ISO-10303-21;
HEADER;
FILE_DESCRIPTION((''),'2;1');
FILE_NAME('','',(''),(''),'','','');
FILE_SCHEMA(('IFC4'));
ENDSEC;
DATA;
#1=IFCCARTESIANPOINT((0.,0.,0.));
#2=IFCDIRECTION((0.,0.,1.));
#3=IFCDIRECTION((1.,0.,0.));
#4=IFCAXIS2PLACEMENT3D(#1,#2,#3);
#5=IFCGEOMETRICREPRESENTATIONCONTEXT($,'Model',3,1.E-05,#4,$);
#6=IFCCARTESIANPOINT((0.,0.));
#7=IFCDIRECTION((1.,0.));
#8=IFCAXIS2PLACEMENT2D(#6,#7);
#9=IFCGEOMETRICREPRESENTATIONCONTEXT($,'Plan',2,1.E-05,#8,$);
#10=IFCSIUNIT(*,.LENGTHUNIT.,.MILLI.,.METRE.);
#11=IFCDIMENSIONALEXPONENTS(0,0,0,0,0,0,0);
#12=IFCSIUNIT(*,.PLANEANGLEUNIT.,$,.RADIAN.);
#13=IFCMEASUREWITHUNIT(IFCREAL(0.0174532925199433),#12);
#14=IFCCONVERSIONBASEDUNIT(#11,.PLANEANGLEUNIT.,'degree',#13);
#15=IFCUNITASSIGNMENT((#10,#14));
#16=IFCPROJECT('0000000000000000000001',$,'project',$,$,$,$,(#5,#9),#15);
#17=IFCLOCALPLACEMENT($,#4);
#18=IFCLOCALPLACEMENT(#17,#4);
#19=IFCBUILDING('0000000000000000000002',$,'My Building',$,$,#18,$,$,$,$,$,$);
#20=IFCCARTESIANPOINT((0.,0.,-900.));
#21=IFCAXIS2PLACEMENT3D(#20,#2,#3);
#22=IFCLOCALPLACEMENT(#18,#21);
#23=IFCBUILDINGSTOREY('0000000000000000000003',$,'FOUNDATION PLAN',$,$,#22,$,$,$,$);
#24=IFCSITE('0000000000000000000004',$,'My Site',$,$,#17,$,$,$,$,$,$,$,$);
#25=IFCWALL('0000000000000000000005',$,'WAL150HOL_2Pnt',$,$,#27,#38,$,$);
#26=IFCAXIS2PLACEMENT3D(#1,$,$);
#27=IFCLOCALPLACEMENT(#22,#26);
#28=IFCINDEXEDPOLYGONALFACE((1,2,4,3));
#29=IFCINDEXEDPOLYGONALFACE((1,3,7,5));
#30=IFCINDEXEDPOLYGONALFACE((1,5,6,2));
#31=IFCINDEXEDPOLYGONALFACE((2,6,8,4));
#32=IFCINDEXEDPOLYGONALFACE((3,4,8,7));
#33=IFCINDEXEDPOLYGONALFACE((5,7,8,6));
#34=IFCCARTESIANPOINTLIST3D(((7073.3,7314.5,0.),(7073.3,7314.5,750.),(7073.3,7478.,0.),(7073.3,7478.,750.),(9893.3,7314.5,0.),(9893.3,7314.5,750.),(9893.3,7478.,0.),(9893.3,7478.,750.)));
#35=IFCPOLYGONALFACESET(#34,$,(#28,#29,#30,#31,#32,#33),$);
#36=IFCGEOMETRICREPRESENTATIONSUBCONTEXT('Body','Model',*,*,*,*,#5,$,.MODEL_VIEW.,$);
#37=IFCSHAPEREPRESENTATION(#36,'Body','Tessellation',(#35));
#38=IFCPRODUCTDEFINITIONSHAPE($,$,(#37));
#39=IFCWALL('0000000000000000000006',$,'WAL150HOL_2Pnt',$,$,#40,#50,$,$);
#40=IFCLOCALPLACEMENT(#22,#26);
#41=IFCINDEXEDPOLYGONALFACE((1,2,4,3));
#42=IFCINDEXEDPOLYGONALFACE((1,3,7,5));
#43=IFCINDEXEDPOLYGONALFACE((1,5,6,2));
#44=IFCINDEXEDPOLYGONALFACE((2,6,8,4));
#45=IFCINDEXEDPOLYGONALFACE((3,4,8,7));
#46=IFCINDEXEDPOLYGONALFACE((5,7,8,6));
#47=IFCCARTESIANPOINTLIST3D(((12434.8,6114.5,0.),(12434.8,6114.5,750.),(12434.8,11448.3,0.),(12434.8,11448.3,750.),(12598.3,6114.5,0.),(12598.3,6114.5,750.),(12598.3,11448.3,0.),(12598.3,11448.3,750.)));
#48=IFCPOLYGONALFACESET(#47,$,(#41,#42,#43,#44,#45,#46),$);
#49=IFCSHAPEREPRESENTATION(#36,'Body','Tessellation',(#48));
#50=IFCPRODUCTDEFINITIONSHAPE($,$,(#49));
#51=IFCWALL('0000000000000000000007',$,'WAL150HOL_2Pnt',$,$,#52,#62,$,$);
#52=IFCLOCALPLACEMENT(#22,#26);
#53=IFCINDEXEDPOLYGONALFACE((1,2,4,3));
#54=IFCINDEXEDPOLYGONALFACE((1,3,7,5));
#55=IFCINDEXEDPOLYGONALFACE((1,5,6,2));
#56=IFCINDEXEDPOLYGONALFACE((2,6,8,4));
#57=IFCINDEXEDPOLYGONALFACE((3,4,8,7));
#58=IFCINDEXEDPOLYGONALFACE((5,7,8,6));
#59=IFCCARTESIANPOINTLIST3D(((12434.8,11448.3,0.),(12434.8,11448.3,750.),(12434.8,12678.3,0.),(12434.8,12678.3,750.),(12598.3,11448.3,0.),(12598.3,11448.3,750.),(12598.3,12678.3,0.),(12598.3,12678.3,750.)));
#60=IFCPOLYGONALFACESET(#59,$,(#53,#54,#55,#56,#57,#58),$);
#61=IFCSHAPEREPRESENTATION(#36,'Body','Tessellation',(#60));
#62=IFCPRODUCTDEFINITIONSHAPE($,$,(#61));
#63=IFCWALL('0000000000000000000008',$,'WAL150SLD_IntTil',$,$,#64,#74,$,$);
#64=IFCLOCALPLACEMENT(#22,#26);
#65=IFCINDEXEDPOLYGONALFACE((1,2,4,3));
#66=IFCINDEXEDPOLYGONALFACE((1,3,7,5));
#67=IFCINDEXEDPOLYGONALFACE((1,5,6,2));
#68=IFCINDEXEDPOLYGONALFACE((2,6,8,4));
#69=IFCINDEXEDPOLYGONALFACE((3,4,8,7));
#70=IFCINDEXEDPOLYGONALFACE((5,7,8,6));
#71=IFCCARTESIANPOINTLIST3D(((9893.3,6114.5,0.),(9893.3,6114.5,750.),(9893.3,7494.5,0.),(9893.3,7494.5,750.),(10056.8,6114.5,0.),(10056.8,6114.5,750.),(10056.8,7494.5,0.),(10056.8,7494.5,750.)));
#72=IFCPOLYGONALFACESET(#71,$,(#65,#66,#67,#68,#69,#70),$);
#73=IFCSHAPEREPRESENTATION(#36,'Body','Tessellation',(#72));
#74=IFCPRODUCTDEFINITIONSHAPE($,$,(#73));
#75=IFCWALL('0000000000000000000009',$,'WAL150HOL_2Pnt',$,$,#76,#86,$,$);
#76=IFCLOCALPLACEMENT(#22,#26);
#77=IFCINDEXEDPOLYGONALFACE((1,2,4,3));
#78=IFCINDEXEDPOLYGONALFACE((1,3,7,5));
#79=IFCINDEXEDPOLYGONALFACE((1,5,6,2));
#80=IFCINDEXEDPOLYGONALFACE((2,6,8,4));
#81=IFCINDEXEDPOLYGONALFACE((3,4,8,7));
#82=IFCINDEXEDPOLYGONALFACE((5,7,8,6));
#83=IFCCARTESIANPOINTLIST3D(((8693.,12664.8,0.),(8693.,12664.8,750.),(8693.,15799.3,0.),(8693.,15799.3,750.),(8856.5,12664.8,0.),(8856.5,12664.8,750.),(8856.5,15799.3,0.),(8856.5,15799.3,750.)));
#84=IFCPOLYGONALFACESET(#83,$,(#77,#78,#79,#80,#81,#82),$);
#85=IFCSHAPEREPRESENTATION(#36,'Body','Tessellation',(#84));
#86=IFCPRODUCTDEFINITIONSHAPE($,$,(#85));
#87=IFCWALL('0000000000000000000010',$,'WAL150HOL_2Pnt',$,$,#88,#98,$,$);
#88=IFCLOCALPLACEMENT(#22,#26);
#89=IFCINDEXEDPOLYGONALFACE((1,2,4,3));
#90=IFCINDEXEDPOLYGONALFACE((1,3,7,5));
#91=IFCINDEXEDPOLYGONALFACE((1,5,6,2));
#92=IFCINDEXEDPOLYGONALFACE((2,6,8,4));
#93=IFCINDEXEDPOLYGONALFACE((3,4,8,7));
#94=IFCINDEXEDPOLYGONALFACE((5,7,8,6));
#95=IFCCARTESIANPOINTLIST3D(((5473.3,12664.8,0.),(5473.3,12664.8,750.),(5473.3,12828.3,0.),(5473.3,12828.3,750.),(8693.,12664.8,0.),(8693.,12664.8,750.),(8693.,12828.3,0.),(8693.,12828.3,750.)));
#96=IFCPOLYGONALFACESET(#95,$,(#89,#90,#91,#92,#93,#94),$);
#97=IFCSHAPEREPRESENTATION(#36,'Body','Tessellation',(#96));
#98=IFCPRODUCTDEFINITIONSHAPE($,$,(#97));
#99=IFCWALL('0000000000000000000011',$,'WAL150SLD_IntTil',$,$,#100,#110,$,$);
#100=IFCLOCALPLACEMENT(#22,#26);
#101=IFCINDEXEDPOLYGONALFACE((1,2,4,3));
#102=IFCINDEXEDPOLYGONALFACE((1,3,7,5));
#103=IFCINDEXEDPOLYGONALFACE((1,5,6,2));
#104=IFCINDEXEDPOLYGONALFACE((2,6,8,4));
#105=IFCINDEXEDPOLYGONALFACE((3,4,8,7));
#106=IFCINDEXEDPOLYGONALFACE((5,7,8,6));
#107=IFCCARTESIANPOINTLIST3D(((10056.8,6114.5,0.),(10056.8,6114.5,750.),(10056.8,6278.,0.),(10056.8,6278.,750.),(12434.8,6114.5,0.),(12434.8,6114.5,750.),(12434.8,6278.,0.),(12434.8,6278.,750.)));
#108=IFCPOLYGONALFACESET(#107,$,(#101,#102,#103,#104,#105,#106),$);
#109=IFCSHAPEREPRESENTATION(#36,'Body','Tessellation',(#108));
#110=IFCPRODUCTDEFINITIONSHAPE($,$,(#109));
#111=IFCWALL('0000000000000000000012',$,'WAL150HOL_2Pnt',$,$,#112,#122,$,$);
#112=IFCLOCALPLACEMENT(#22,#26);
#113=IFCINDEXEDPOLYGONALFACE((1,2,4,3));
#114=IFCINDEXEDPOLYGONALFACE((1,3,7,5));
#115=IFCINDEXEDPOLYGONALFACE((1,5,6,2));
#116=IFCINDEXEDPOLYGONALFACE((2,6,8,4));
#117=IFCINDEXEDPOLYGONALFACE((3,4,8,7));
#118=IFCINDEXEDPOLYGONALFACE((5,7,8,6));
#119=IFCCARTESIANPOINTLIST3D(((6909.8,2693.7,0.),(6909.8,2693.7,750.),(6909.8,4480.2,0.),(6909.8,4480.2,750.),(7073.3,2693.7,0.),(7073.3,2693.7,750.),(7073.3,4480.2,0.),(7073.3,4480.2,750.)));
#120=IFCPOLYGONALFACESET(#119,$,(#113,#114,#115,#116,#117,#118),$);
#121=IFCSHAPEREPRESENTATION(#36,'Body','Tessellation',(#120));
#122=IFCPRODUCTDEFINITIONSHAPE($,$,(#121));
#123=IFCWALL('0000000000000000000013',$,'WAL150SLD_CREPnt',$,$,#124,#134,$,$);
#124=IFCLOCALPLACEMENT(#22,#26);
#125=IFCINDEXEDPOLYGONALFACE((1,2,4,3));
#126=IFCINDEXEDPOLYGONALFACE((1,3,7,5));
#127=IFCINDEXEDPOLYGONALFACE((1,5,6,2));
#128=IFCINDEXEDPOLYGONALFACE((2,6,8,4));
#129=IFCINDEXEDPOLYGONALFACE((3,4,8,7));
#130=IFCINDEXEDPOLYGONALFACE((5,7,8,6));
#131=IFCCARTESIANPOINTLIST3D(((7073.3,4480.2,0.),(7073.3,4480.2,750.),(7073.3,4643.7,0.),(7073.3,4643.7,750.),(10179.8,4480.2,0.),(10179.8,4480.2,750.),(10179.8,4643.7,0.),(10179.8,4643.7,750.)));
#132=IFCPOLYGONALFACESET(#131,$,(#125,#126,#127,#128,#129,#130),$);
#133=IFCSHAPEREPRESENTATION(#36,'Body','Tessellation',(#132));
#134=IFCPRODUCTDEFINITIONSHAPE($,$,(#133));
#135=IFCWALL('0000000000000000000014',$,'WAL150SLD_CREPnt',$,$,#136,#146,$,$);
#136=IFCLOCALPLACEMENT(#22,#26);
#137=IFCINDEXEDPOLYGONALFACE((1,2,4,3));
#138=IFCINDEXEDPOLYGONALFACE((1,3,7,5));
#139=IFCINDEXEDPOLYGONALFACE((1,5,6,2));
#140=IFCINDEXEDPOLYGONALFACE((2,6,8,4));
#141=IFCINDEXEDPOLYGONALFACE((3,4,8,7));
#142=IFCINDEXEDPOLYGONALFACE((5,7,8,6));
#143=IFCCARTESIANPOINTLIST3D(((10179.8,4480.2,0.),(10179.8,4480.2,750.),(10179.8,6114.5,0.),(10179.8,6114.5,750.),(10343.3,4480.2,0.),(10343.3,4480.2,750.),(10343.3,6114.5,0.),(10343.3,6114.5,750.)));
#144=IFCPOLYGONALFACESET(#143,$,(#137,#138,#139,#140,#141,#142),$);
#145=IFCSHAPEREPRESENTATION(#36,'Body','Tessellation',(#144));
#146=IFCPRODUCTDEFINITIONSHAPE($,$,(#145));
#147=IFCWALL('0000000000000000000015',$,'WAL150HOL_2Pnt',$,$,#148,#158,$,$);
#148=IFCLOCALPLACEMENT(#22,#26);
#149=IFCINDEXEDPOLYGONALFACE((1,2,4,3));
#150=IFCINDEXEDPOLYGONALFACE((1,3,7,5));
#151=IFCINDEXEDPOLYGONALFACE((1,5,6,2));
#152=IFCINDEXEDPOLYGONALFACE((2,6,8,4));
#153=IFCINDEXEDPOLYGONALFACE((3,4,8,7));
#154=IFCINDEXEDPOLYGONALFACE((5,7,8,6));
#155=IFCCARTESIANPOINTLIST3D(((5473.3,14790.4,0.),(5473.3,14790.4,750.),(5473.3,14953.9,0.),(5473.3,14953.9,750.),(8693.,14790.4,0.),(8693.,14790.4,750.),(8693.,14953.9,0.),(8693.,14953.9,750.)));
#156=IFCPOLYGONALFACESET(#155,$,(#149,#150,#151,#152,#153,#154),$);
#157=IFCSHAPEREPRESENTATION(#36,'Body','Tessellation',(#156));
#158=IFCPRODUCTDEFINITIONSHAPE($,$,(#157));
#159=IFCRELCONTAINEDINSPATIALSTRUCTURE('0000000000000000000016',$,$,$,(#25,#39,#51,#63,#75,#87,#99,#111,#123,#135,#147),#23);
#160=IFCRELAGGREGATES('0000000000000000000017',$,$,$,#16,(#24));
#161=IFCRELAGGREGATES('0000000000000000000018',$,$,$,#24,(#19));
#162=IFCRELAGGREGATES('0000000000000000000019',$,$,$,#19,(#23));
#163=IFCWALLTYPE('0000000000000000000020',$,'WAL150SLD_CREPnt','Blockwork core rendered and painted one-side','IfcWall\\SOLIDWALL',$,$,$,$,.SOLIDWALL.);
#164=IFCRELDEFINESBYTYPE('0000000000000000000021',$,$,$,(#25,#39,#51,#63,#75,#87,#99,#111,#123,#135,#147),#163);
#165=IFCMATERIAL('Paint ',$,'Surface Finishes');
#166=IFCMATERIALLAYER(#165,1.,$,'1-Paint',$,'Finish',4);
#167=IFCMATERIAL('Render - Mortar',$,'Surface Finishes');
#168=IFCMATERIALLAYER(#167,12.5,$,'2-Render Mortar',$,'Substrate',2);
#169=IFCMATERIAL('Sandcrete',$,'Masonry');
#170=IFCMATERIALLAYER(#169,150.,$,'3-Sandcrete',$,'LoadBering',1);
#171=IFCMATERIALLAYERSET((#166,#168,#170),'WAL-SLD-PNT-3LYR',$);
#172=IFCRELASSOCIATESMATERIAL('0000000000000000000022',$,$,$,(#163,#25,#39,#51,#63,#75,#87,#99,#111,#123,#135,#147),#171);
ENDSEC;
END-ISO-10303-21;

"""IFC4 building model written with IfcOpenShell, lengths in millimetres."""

from ifc_helpers import new_model, entity, si_unit, converted_unit, frame, origin_with_axes, origin_2d_with_axis, place, context, subcontext, project, spatial, indexed_curve, outline, extrude, material, layer, layer_set, layer_usage, type_object, element, save


model = new_model("IFC4")

# Units and contexts
model_context = context("Model", 3, precision=1e-05, world=origin_with_axes())
plan_context = context("Plan", 2, precision=1e-05, world=origin_2d_with_axis())
body_context = subcontext(model_context, "Body", "Model", "MODEL_VIEW")
ifc_project = project(units=[si_unit("LENGTHUNIT", "METRE", prefix="MILLI"), converted_unit("PLANEANGLEUNIT", "degree", entity("IfcReal", 0.0174532925199433), si_unit("PLANEANGLEUNIT", "RADIAN"), dimensions=[0, 0, 0, 0, 0, 0, 0])], contexts=[model_context, plan_context])

# Site, building, storey
site_placement = place(None, origin_with_axes())
site = spatial("IfcSite", under=ifc_project, at=site_placement, Name="My Site")
building_placement = place(site_placement, origin_with_axes())
building = spatial("IfcBuilding", under=site, at=building_placement, Name="My Building")
storey_placement = place(building_placement, frame((0.0, 0.0, -900.0), z_axis=(0.0, 0.0, 1.0), x_axis=(1.0, 0.0, 0.0)))
storey = spatial("IfcBuildingStorey", under=building, at=storey_placement, Name="FOUNDATION PLAN")

# Walls
ifc_material_1 = material(Name="Sandcrete", Category="Masonry")
ifc_material_2 = material(Name="Paint ", Category="Surface Finishes")
ifc_layer_1 = layer(ifc_material_2, 1.0, Name="1-Paint", Category="Finish", Priority=4)
ifc_material_3 = material(Name="Render - Mortar", Category="Surface Finishes")
ifc_layer_2 = layer(ifc_material_3, 12.5, Name="2-Render Mortar", Category="Substrate", Priority=2)
ifc_layer_3 = layer(ifc_material_1, 150.0, Name="3-Sandcrete", Category="LoadBering", Priority=1)
ifc_layer_set_1 = layer_set([ifc_layer_1, ifc_layer_2, ifc_layer_3], Name="WAL-SLD-PNT-3LYR")
wall_type_1 = type_object("IfcWallType", Name="WAL150SLD_CREPnt", Description="Blockwork core rendered and painted one-side", ApplicableOccurrence="IfcWall\\SOLIDWALL", PredefinedType="SOLIDWALL", material=ifc_layer_set_1)
ifc_layer_usage_1 = layer_usage(ifc_layer_set_1, "AXIS2", "POSITIVE", 0.0)
wall_1_placement = place(storey_placement, frame((7073.3, 7314.5, 0.0), z_axis=(0.0, 0.0, 1.0), x_axis=(1.0, 0.0, 0.0)))
element("IfcWall", 1, at=wall_1_placement, inside=storey, type_object=wall_type_1, material=ifc_layer_usage_1, Name="WAL150HOL_2Pnt", context=body_context, shape_type="SweptSolid", body=[
    extrude(outline(indexed_curve([(0.0, 0.0), (0.0, 163.5), (2820.0, 163.5), (2820.0, 0.0), (0.0, 0.0)], self_intersect=False)), origin_with_axes(), (0.0, 0.0, 1.0), 750.0),
])
ifc_layer_usage_2 = layer_usage(ifc_layer_set_1, "AXIS2", "POSITIVE", 0.0)
wall_2_placement = place(storey_placement, frame((12598.3, 6114.5, 0.0), z_axis=(0.0, 0.0, 1.0), x_axis=(0.000002, 1.0, 0.0)))
element("IfcWall", 2, at=wall_2_placement, inside=storey, type_object=wall_type_1, material=ifc_layer_usage_2, Name="WAL150HOL_2Pnt", context=body_context, shape_type="SweptSolid", body=[
    extrude(outline(indexed_curve([(0.0, 0.0), (0.0, 163.5), (5333.8, 163.5), (5333.8, 0.0), (0.0, 0.0)], self_intersect=False)), origin_with_axes(), (0.0, 0.0, 1.0), 750.0),
])
ifc_layer_usage_3 = layer_usage(ifc_layer_set_1, "AXIS2", "POSITIVE", 0.0)
wall_3_placement = place(storey_placement, frame((12598.3, 11448.3, 0.0), z_axis=(0.0, 0.0, 1.0), x_axis=(0.000002, 1.0, 0.0)))
element("IfcWall", 3, at=wall_3_placement, inside=storey, type_object=wall_type_1, material=ifc_layer_usage_3, Name="WAL150HOL_2Pnt", context=body_context, shape_type="SweptSolid", body=[
    extrude(outline(indexed_curve([(0.0, 0.0), (0.0, 163.5), (1230.0, 163.5), (1230.0, 0.0), (0.0, 0.0)], self_intersect=False)), origin_with_axes(), (0.0, 0.0, 1.0), 750.0),
])
ifc_layer_usage_4 = layer_usage(ifc_layer_set_1, "AXIS2", "POSITIVE", 0.0)
wall_4_placement = place(storey_placement, frame((9893.3, 7494.5, 0.0), z_axis=(0.0, 0.0, 1.0), x_axis=(-0.000001, -1.0, 0.0)))
element("IfcWall", 4, at=wall_4_placement, inside=storey, type_object=wall_type_1, material=ifc_layer_usage_4, Name="WAL150SLD_IntTil", context=body_context, shape_type="SweptSolid", body=[
    extrude(outline(indexed_curve([(0.0, 0.0), (0.0, 163.5), (1380.0, 163.5), (1380.0, 0.0), (0.0, 0.0)], self_intersect=False)), origin_with_axes(), (0.0, 0.0, 1.0), 750.0),
])
ifc_layer_usage_5 = layer_usage(ifc_layer_set_1, "AXIS2", "POSITIVE", 0.0)
wall_5_placement = place(storey_placement, frame((8693.0, 15799.3, 0.0), z_axis=(0.0, 0.0, 1.0), x_axis=(-0.000001, -1.0, 0.0)))
element("IfcWall", 5, at=wall_5_placement, inside=storey, type_object=wall_type_1, material=ifc_layer_usage_5, Name="WAL150HOL_2Pnt", context=body_context, shape_type="SweptSolid", body=[
    extrude(outline(indexed_curve([(0.0, 0.0), (0.0, 163.5), (3134.5, 163.5), (3134.5, 0.0), (0.0, 0.0)], self_intersect=False)), origin_with_axes(), (0.0, 0.0, 1.0), 750.0),
])
ifc_layer_usage_6 = layer_usage(ifc_layer_set_1, "AXIS2", "POSITIVE", 0.0)
wall_6_placement = place(storey_placement, frame((8693.0, 12828.3, 0.0), z_axis=(0.0, 0.0, 1.0), x_axis=(-1.0, 0.000001, 0.0)))
element("IfcWall", 6, at=wall_6_placement, inside=storey, type_object=wall_type_1, material=ifc_layer_usage_6, Name="WAL150HOL_2Pnt", context=body_context, shape_type="SweptSolid", body=[
    extrude(outline(indexed_curve([(0.0, 0.0), (0.0, 163.5), (3219.7, 163.5), (3219.7, 0.0), (0.0, 0.0)], self_intersect=False)), origin_with_axes(), (0.0, 0.0, 1.0), 750.0),
])
ifc_layer_usage_7 = layer_usage(ifc_layer_set_1, "AXIS2", "POSITIVE", 0.0)
wall_7_placement = place(storey_placement, frame((10056.8, 6114.5, 0.0), z_axis=(0.0, 0.0, 1.0), x_axis=(1.0, 0.0, 0.0)))
element("IfcWall", 7, at=wall_7_placement, inside=storey, type_object=wall_type_1, material=ifc_layer_usage_7, Name="WAL150SLD_IntTil", context=body_context, shape_type="SweptSolid", body=[
    extrude(outline(indexed_curve([(0.0, 0.0), (0.0, 163.5), (2378.0, 163.5), (2378.0, 0.0), (0.0, 0.0)], self_intersect=False)), origin_with_axes(), (0.0, 0.0, 1.0), 750.0),
])
ifc_layer_usage_8 = layer_usage(ifc_layer_set_1, "AXIS2", "POSITIVE", 0.0)
wall_8_placement = place(storey_placement, frame((7073.3, 2693.7, 0.0), z_axis=(0.0, 0.0, 1.0), x_axis=(0.000002, 1.0, 0.0)))
element("IfcWall", 8, at=wall_8_placement, inside=storey, type_object=wall_type_1, material=ifc_layer_usage_8, Name="WAL150HOL_2Pnt", context=body_context, shape_type="SweptSolid", body=[
    extrude(outline(indexed_curve([(0.0, 0.0), (0.0, 163.5), (1786.5, 163.5), (1786.5, 0.0), (0.0, 0.0)], self_intersect=False)), origin_with_axes(), (0.0, 0.0, 1.0), 750.0),
])
ifc_layer_usage_9 = layer_usage(ifc_layer_set_1, "AXIS2", "POSITIVE", 0.0)
wall_9_placement = place(storey_placement, frame((7073.3, 4480.2, 0.0), z_axis=(0.0, 0.0, 1.0), x_axis=(1.0, 0.0, 0.0)))
element("IfcWall", 9, at=wall_9_placement, inside=storey, type_object=wall_type_1, material=ifc_layer_usage_9, Name="WAL150SLD_CREPnt", context=body_context, shape_type="SweptSolid", body=[
    extrude(outline(indexed_curve([(0.0, 0.0), (0.0, 163.5), (3106.5, 163.5), (3106.5, 0.0), (0.0, 0.0)], self_intersect=False)), origin_with_axes(), (0.0, 0.0, 1.0), 750.0),
])
ifc_layer_usage_10 = layer_usage(ifc_layer_set_1, "AXIS2", "POSITIVE", 0.0)
wall_10_placement = place(storey_placement, frame((10343.3, 4480.2, 0.0), z_axis=(0.0, 0.0, 1.0), x_axis=(0.000002, 1.0, 0.0)))
element("IfcWall", 10, at=wall_10_placement, inside=storey, type_object=wall_type_1, material=ifc_layer_usage_10, Name="WAL150SLD_CREPnt", context=body_context, shape_type="SweptSolid", body=[
    extrude(outline(indexed_curve([(0.0, 0.0), (0.0, 163.5), (1634.3, 163.5), (1634.3, 0.0), (0.0, 0.0)], self_intersect=False)), origin_with_axes(), (0.0, 0.0, 1.0), 750.0),
])
ifc_layer_usage_11 = layer_usage(ifc_layer_set_1, "AXIS2", "POSITIVE", 0.0)
wall_11_placement = place(storey_placement, frame((8693.0, 14953.9, 0.0), z_axis=(0.0, 0.0, 1.0), x_axis=(-1.0, 0.0, 0.0)))
element("IfcWall", 11, at=wall_11_placement, inside=storey, type_object=wall_type_1, material=ifc_layer_usage_11, Name="WAL150HOL_2Pnt", context=body_context, shape_type="SweptSolid", body=[
    extrude(outline(indexed_curve([(0.0, 0.0), (0.0, 163.5), (3219.7, 163.5), (3219.7, 0.0), (0.0, 0.0)], self_intersect=False)), origin_with_axes(), (0.0, 0.0, 1.0), 750.0),
])

save(model, "model.ifc")
